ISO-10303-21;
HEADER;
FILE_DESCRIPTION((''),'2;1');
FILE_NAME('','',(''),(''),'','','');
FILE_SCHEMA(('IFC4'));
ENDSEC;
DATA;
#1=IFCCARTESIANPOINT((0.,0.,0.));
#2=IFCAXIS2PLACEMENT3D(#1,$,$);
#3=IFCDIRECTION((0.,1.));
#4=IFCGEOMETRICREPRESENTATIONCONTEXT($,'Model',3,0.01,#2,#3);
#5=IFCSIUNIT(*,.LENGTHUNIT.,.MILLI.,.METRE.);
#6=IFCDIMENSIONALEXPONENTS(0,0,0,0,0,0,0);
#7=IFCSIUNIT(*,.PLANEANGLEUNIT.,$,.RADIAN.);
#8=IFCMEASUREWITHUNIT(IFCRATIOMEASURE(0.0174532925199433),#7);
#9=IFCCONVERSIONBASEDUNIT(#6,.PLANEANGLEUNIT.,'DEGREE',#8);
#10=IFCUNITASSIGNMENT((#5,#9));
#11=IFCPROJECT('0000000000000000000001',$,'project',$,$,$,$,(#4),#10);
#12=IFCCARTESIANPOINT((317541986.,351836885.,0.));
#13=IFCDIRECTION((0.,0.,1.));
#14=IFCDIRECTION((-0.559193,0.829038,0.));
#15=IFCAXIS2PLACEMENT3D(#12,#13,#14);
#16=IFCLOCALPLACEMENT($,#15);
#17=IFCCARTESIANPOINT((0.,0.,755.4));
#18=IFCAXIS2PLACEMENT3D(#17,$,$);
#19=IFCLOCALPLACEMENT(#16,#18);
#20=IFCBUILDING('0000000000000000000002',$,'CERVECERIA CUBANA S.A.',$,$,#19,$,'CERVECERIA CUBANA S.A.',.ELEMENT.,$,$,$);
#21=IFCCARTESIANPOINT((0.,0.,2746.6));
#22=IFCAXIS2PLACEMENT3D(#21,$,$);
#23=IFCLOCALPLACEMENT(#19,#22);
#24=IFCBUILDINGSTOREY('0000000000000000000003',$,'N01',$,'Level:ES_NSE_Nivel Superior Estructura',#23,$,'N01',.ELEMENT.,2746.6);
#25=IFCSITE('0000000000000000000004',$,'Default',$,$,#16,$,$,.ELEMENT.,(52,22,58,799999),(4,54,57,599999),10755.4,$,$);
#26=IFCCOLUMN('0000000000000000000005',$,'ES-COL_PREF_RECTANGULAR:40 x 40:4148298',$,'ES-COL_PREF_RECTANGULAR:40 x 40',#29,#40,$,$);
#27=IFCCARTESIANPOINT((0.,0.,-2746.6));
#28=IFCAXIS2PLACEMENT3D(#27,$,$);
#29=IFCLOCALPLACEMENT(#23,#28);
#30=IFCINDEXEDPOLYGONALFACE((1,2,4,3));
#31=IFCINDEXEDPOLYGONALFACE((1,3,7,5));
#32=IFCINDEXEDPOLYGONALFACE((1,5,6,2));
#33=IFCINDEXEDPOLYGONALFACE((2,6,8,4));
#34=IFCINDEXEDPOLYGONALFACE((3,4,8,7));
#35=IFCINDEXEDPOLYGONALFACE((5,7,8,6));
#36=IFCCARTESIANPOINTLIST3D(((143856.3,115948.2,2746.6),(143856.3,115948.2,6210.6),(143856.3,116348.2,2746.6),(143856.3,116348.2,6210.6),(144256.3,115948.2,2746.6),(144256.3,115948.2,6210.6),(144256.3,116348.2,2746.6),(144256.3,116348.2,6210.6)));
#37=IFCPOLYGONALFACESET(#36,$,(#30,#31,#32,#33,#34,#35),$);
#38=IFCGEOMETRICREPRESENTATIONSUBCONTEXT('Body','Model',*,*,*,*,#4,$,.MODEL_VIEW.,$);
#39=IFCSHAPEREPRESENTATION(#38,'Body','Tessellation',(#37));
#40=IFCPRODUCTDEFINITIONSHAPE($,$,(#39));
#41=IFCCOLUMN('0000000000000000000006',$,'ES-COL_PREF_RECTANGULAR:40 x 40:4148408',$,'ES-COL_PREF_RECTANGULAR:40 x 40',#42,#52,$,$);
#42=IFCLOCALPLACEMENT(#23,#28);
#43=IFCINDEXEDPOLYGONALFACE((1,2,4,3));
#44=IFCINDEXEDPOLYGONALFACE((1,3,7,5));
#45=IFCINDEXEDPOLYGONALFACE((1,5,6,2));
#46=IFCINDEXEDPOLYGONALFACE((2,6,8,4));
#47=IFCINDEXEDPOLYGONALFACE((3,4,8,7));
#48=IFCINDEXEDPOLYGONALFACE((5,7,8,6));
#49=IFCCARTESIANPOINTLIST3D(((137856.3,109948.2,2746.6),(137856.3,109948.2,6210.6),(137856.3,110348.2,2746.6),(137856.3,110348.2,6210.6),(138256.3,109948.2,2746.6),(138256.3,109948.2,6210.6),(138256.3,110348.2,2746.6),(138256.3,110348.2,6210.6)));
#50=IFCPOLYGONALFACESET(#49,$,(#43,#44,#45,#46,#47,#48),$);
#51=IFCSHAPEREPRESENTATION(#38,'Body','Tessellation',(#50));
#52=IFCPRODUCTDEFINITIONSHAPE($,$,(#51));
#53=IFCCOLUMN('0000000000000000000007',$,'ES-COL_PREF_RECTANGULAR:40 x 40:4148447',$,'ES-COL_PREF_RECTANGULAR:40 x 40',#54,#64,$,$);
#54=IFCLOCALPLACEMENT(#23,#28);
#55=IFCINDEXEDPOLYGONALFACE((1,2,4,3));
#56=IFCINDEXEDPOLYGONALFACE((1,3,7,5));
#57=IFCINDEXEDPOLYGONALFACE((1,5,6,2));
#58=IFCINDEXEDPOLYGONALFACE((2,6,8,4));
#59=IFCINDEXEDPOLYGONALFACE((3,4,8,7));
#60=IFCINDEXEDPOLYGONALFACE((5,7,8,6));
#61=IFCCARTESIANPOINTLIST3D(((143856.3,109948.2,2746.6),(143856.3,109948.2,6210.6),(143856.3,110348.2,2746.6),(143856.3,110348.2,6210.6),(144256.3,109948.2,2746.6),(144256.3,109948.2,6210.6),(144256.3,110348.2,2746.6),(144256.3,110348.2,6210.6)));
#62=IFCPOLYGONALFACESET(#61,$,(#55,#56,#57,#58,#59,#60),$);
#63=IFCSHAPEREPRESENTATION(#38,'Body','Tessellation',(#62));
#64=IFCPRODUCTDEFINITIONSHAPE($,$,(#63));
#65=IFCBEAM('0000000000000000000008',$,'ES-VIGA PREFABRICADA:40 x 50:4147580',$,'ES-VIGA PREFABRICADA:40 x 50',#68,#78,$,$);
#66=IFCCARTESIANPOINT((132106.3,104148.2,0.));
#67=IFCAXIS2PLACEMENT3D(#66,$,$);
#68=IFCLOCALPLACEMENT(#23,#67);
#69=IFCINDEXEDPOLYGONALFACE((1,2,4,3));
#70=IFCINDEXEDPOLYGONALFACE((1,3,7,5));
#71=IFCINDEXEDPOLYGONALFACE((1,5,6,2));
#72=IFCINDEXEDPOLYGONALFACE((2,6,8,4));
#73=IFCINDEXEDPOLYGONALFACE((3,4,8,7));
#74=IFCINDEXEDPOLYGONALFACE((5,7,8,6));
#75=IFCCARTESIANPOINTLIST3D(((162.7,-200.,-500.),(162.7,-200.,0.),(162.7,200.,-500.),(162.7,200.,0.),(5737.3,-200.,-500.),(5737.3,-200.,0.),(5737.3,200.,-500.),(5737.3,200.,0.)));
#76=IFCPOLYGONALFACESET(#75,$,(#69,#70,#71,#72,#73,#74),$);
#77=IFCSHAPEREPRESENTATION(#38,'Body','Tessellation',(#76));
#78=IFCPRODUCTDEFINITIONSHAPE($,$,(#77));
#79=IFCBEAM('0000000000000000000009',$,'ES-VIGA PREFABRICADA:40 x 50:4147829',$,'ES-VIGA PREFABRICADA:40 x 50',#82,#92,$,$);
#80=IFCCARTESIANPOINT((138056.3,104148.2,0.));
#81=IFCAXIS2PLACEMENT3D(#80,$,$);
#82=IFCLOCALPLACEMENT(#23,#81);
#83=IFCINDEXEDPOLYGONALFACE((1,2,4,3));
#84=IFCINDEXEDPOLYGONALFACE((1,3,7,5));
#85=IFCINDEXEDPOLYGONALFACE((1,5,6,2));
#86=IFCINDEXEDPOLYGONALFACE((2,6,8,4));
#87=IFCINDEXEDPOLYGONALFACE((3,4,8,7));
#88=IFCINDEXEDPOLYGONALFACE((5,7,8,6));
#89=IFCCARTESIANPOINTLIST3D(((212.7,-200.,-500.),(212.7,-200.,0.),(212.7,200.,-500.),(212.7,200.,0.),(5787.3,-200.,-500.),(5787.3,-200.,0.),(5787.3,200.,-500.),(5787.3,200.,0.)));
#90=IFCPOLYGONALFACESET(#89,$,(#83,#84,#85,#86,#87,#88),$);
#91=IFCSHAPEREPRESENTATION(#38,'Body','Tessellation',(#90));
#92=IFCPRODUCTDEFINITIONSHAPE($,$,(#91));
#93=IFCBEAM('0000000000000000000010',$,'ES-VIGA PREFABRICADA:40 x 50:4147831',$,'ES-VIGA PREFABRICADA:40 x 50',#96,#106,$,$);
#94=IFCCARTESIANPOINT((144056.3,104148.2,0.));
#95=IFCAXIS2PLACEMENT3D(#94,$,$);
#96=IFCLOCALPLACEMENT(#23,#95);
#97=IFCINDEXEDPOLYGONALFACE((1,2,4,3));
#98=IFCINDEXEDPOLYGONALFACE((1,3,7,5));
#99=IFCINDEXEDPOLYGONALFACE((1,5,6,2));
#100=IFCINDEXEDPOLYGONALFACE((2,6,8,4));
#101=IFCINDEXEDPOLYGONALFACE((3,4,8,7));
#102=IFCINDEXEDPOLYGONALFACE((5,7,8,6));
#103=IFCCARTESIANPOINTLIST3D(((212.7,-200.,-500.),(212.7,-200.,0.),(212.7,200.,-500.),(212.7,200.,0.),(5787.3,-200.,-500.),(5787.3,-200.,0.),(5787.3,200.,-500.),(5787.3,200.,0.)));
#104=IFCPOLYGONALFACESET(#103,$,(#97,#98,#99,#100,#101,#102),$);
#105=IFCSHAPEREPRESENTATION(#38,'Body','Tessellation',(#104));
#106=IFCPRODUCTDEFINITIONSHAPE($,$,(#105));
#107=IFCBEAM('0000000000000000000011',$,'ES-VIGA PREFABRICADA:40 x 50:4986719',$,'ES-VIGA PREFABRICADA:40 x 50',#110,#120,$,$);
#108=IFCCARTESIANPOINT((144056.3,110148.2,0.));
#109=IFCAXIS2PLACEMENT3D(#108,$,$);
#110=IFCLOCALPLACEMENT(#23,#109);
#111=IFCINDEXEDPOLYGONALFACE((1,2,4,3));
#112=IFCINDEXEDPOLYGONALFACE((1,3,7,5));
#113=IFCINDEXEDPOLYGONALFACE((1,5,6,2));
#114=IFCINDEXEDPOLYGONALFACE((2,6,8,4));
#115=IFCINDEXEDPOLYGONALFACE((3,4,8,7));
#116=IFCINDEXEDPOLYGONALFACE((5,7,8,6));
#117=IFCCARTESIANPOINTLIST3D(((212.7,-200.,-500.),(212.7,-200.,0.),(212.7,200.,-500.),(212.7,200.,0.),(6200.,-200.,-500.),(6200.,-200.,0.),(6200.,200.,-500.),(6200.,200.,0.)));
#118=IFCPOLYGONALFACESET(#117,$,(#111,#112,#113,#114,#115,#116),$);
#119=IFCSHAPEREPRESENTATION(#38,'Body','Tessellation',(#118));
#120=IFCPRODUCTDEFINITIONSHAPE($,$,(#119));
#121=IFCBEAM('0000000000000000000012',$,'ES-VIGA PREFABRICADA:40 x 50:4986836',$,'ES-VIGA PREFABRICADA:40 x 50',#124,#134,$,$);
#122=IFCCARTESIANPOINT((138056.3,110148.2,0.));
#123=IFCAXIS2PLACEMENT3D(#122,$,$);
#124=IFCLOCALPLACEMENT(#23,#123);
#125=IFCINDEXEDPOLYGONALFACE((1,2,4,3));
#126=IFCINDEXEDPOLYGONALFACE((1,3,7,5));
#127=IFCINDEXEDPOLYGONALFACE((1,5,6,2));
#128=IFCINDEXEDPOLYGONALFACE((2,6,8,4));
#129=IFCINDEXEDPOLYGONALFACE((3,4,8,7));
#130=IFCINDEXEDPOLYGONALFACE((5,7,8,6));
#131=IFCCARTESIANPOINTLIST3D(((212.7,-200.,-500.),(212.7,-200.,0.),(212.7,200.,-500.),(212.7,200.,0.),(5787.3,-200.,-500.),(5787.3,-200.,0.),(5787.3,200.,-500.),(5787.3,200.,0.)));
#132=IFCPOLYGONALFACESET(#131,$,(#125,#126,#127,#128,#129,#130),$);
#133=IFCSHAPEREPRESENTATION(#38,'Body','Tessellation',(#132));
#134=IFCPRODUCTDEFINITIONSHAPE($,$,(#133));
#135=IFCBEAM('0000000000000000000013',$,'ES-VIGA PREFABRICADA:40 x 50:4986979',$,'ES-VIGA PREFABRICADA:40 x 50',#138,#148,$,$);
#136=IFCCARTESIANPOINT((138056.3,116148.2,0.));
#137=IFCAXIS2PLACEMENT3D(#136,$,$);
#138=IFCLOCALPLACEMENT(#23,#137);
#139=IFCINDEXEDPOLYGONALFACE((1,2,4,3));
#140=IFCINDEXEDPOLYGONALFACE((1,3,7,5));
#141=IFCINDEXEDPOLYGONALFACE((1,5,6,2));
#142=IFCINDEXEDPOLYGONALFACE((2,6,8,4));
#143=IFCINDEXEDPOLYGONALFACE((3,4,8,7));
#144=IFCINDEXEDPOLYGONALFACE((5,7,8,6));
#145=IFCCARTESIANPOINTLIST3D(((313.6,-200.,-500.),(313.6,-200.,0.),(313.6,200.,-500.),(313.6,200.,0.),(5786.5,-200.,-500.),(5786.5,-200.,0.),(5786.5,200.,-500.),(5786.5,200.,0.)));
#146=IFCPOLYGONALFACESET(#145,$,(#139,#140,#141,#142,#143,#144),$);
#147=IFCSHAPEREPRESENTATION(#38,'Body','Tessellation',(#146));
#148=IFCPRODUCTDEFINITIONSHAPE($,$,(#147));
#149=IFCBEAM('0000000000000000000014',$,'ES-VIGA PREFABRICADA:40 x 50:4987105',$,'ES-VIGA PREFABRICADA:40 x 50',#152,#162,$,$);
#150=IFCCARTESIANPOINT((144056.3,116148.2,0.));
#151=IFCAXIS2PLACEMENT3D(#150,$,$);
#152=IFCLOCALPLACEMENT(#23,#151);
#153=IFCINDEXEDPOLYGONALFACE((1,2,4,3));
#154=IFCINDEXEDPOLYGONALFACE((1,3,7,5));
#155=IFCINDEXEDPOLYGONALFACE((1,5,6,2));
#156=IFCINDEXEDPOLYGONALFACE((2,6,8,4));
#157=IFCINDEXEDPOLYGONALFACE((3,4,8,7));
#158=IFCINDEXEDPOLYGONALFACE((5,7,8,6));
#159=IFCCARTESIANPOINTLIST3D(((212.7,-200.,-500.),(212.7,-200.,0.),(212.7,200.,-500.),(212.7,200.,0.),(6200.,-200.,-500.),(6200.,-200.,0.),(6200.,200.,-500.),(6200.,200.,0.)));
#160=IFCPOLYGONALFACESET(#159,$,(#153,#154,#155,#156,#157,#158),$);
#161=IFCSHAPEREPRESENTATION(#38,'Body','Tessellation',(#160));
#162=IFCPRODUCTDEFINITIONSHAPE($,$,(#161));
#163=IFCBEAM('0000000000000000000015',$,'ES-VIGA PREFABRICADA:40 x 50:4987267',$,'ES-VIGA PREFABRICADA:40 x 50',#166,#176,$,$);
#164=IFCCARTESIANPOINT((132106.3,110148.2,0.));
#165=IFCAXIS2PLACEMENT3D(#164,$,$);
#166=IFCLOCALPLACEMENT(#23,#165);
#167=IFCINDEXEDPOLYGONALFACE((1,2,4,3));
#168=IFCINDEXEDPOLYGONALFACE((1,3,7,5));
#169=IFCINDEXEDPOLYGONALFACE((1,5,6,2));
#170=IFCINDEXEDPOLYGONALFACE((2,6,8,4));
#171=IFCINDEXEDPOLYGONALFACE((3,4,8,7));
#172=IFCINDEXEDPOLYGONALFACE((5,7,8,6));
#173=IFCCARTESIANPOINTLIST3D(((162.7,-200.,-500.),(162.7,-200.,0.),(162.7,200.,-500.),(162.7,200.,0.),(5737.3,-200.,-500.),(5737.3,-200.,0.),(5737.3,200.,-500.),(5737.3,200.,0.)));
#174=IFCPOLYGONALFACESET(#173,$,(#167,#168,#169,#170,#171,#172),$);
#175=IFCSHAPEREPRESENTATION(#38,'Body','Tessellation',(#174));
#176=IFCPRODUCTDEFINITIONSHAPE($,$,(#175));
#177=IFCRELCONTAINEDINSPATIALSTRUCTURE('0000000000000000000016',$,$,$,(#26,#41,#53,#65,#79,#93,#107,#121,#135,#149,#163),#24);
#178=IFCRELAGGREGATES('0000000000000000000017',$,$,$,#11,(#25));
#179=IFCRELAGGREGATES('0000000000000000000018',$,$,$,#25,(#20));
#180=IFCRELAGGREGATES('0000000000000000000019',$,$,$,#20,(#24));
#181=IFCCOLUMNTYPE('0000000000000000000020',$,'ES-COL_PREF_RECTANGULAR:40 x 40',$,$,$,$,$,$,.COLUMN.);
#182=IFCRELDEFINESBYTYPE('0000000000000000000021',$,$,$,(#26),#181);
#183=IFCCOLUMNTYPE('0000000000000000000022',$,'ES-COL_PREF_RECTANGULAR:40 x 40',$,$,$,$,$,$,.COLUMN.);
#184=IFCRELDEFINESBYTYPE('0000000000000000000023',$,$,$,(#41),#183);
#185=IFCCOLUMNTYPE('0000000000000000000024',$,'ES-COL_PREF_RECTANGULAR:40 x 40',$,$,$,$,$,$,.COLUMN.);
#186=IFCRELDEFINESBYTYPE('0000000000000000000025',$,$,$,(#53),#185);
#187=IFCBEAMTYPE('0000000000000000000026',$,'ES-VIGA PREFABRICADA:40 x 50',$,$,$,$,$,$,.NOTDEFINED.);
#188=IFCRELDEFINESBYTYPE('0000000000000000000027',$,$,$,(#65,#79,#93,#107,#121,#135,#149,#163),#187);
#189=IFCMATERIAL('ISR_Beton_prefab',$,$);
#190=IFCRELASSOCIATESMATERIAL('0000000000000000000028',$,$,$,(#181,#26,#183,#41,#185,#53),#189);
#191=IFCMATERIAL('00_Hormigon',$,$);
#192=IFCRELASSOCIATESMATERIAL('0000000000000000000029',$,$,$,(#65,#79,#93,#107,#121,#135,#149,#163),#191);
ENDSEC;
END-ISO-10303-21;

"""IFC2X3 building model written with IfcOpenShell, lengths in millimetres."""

from ifc_helpers import new_model, entity, si_unit, converted_unit, direction, frame, frame_2d, origin, origin_2d_with_axis, place, context, subcontext, project, spatial, rectangle, extrude, source, transform, mapped, material, type_object, type_shapes, element, save


model = new_model("IFC2X3")

# Units and contexts
model_context = context("Model", 3, precision=0.01, world=origin(), true_north=direction((0.0, 1.0)))
body_context = subcontext(model_context, "Body", "Model", "MODEL_VIEW")
ifc_project = project(units=[si_unit("LENGTHUNIT", "METRE", prefix="MILLI"), converted_unit("PLANEANGLEUNIT", "DEGREE", entity("IfcRatioMeasure", 0.0174532925199433), si_unit("PLANEANGLEUNIT", "RADIAN"), dimensions=[0, 0, 0, 0, 0, 0, 0])], contexts=[model_context])

# Site, building, storey
site_placement = place(None, frame((317541986.0, 351836885.0, 0.0), z_axis=(0.0, 0.0, 1.0), x_axis=(-0.559193, 0.829038, 0.0)))
site = spatial("IfcSite", under=ifc_project, at=site_placement, Name="Default", CompositionType="ELEMENT", RefLatitude=(52, 22, 58, 799999), RefLongitude=(4, 54, 57, 599999), RefElevation=10755.4)
building_placement = place(site_placement, frame((0.0, 0.0, 755.4)))
building = spatial("IfcBuilding", under=site, at=building_placement, Name="CERVECERIA CUBANA S.A.", LongName="CERVECERIA CUBANA S.A.", CompositionType="ELEMENT")
storey_placement = place(building_placement, frame((0.0, 0.0, 2746.6)))
storey = spatial("IfcBuildingStorey", under=building, at=storey_placement, Name="N01", ObjectType="Level:ES_NSE_Nivel Superior Estructura", LongName="N01", CompositionType="ELEMENT", Elevation=2746.6)

# Columns
ifc_material_1 = material(Name="ISR_Beton_prefab")
column_type_1 = type_object("IfcColumnType", Name="ES-COL_PREF_RECTANGULAR:40 x 40", PredefinedType="COLUMN", material=ifc_material_1)
shared_shape_1 = source(origin(), body_context, "Body", "SweptSolid", [
    extrude(rectangle(XDim=400.0, YDim=400.0, at=frame_2d((0.0, 0.0), x_axis=(1.0, 0.0))), frame((144056.3, 116148.2, 2746.6), z_axis=(0.0, 0.0, 1.0), x_axis=(0.0, -1.0, 0.0)), (0.0, 0.0, 1.0), 3464.0),
])
type_shapes(column_type_1, [shared_shape_1])
column_1_placement = place(storey_placement, frame((0.0, 0.0, -2746.6)))
element("IfcColumn", 1, at=column_1_placement, inside=storey, type_object=column_type_1, material=ifc_material_1, Name="ES-COL_PREF_RECTANGULAR:40 x 40:4148298", ObjectType="ES-COL_PREF_RECTANGULAR:40 x 40", context=body_context, shape_type="MappedRepresentation", body=[
    mapped(shared_shape_1, transform((0.0, 0.0, 0.0), scale=1.0)),
])
column_type_2 = type_object("IfcColumnType", Name="ES-COL_PREF_RECTANGULAR:40 x 40", PredefinedType="COLUMN", material=ifc_material_1)
shared_shape_2 = source(origin(), body_context, "Body", "SweptSolid", [
    extrude(rectangle(XDim=400.0, YDim=400.0, at=origin_2d_with_axis()), frame((138056.3, 110148.2, 2746.6), z_axis=(0.0, 0.0, 1.0), x_axis=(0.0, -1.0, 0.0)), (0.0, 0.0, 1.0), 3464.0),
])
type_shapes(column_type_2, [shared_shape_2])
column_2_placement = place(storey_placement, frame((0.0, 0.0, -2746.6)))
element("IfcColumn", 2, at=column_2_placement, inside=storey, type_object=column_type_2, material=ifc_material_1, Name="ES-COL_PREF_RECTANGULAR:40 x 40:4148408", ObjectType="ES-COL_PREF_RECTANGULAR:40 x 40", context=body_context, shape_type="MappedRepresentation", body=[
    mapped(shared_shape_2, transform((0.0, 0.0, 0.0), scale=1.0)),
])
column_type_3 = type_object("IfcColumnType", Name="ES-COL_PREF_RECTANGULAR:40 x 40", PredefinedType="COLUMN", material=ifc_material_1)
shared_shape_3 = source(origin(), body_context, "Body", "SweptSolid", [
    extrude(rectangle(XDim=400.0, YDim=400.0, at=frame_2d((0.0, 0.0), x_axis=(1.0, 0.0))), frame((144056.3, 110148.2, 2746.6), z_axis=(0.0, 0.0, 1.0), x_axis=(0.0, -1.0, 0.0)), (0.0, 0.0, 1.0), 3464.0),
])
type_shapes(column_type_3, [shared_shape_3])
column_3_placement = place(storey_placement, frame((0.0, 0.0, -2746.6)))
element("IfcColumn", 3, at=column_3_placement, inside=storey, type_object=column_type_3, material=ifc_material_1, Name="ES-COL_PREF_RECTANGULAR:40 x 40:4148447", ObjectType="ES-COL_PREF_RECTANGULAR:40 x 40", context=body_context, shape_type="MappedRepresentation", body=[
    mapped(shared_shape_3, transform((0.0, 0.0, 0.0), scale=1.0)),
])

# Beams
ifc_material_2 = material(Name="00_Hormigon")
beam_type = type_object("IfcBeamType", Name="ES-VIGA PREFABRICADA:40 x 50", PredefinedType="NOTDEFINED")
beam_1_placement = place(storey_placement, frame((132106.3, 104148.2, 0.0)))
element("IfcBeam", 4, at=beam_1_placement, inside=storey, type_object=beam_type, material=ifc_material_2, Name="ES-VIGA PREFABRICADA:40 x 50:4147580", ObjectType="ES-VIGA PREFABRICADA:40 x 50", context=body_context, shape_type="SweptSolid", body=[
    extrude(rectangle(XDim=500.0, YDim=400.0, at=origin_2d_with_axis()), frame((162.7, 0.0, -250.0), z_axis=(1.0, 0.0, 0.0), x_axis=(0.0, 0.0, -1.0)), (0.0, 0.0, 1.0), 5574.6),
])
beam_2_placement = place(storey_placement, frame((138056.3, 104148.2, 0.0)))
element("IfcBeam", 5, at=beam_2_placement, inside=storey, type_object=beam_type, material=ifc_material_2, Name="ES-VIGA PREFABRICADA:40 x 50:4147829", ObjectType="ES-VIGA PREFABRICADA:40 x 50", context=body_context, shape_type="SweptSolid", body=[
    extrude(rectangle(XDim=500.0, YDim=400.0, at=frame_2d((0.0, 0.0), x_axis=(1.0, 0.0))), frame((212.7, 0.0, -250.0), z_axis=(1.0, 0.0, 0.0), x_axis=(0.0, 0.0, -1.0)), (0.0, 0.0, 1.0), 5574.6),
])
beam_3_placement = place(storey_placement, frame((144056.3, 104148.2, 0.0)))
element("IfcBeam", 6, at=beam_3_placement, inside=storey, type_object=beam_type, material=ifc_material_2, Name="ES-VIGA PREFABRICADA:40 x 50:4147831", ObjectType="ES-VIGA PREFABRICADA:40 x 50", context=body_context, shape_type="SweptSolid", body=[
    extrude(rectangle(XDim=500.0, YDim=400.0, at=frame_2d((0.0, 0.0), x_axis=(1.0, 0.0))), frame((212.7, 0.0, -250.0), z_axis=(1.0, 0.0, 0.0), x_axis=(0.0, 0.0, -1.0)), (0.0, 0.0, 1.0), 5574.6),
])
beam_4_placement = place(storey_placement, frame((144056.3, 110148.2, 0.0)))
element("IfcBeam", 7, at=beam_4_placement, inside=storey, type_object=beam_type, material=ifc_material_2, Name="ES-VIGA PREFABRICADA:40 x 50:4986719", ObjectType="ES-VIGA PREFABRICADA:40 x 50", context=body_context, shape_type="SweptSolid", body=[
    extrude(rectangle(XDim=500.0, YDim=400.0, at=frame_2d((0.0, 0.0), x_axis=(1.0, 0.0))), frame((212.7, 0.0, -250.0), z_axis=(1.0, 0.0, 0.0), x_axis=(0.0, 0.0, -1.0)), (0.0, 0.0, 1.0), 5987.3),
])
beam_5_placement = place(storey_placement, frame((138056.3, 110148.2, 0.0)))
element("IfcBeam", 8, at=beam_5_placement, inside=storey, type_object=beam_type, material=ifc_material_2, Name="ES-VIGA PREFABRICADA:40 x 50:4986836", ObjectType="ES-VIGA PREFABRICADA:40 x 50", context=body_context, shape_type="SweptSolid", body=[
    extrude(rectangle(XDim=500.0, YDim=400.0, at=frame_2d((0.0, 0.0), x_axis=(1.0, 0.0))), frame((212.7, 0.0, -250.0), z_axis=(1.0, 0.0, 0.0), x_axis=(0.0, 0.0, -1.0)), (0.0, 0.0, 1.0), 5574.6),
])
beam_6_placement = place(storey_placement, frame((138056.3, 116148.2, 0.0)))
element("IfcBeam", 9, at=beam_6_placement, inside=storey, type_object=beam_type, material=ifc_material_2, Name="ES-VIGA PREFABRICADA:40 x 50:4986979", ObjectType="ES-VIGA PREFABRICADA:40 x 50", context=body_context, shape_type="SweptSolid", body=[
    extrude(rectangle(XDim=500.0, YDim=400.0, at=frame_2d((0.0, 0.0), x_axis=(1.0, 0.0))), frame((313.6, 0.0, -250.0), z_axis=(1.0, 0.0, 0.0), x_axis=(0.0, 0.0, -1.0)), (0.0, 0.0, 1.0), 5472.8),
])
beam_7_placement = place(storey_placement, frame((144056.3, 116148.2, 0.0)))
element("IfcBeam", 10, at=beam_7_placement, inside=storey, type_object=beam_type, material=ifc_material_2, Name="ES-VIGA PREFABRICADA:40 x 50:4987105", ObjectType="ES-VIGA PREFABRICADA:40 x 50", context=body_context, shape_type="SweptSolid", body=[
    extrude(rectangle(XDim=500.0, YDim=400.0, at=origin_2d_with_axis()), frame((212.7, 0.0, -250.0), z_axis=(1.0, 0.0, 0.0), x_axis=(0.0, 0.0, -1.0)), (0.0, 0.0, 1.0), 5987.3),
])
beam_8_placement = place(storey_placement, frame((132106.3, 110148.2, 0.0)))
element("IfcBeam", 11, at=beam_8_placement, inside=storey, type_object=beam_type, material=ifc_material_2, Name="ES-VIGA PREFABRICADA:40 x 50:4987267", ObjectType="ES-VIGA PREFABRICADA:40 x 50", context=body_context, shape_type="SweptSolid", body=[
    extrude(rectangle(XDim=500.0, YDim=400.0, at=frame_2d((0.0, 0.0), x_axis=(1.0, 0.0))), frame((162.7, 0.0, -250.0), z_axis=(1.0, 0.0, 0.0), x_axis=(0.0, 0.0, -1.0)), (0.0, 0.0, 1.0), 5574.6),
])

save(model, "model.ifc")
